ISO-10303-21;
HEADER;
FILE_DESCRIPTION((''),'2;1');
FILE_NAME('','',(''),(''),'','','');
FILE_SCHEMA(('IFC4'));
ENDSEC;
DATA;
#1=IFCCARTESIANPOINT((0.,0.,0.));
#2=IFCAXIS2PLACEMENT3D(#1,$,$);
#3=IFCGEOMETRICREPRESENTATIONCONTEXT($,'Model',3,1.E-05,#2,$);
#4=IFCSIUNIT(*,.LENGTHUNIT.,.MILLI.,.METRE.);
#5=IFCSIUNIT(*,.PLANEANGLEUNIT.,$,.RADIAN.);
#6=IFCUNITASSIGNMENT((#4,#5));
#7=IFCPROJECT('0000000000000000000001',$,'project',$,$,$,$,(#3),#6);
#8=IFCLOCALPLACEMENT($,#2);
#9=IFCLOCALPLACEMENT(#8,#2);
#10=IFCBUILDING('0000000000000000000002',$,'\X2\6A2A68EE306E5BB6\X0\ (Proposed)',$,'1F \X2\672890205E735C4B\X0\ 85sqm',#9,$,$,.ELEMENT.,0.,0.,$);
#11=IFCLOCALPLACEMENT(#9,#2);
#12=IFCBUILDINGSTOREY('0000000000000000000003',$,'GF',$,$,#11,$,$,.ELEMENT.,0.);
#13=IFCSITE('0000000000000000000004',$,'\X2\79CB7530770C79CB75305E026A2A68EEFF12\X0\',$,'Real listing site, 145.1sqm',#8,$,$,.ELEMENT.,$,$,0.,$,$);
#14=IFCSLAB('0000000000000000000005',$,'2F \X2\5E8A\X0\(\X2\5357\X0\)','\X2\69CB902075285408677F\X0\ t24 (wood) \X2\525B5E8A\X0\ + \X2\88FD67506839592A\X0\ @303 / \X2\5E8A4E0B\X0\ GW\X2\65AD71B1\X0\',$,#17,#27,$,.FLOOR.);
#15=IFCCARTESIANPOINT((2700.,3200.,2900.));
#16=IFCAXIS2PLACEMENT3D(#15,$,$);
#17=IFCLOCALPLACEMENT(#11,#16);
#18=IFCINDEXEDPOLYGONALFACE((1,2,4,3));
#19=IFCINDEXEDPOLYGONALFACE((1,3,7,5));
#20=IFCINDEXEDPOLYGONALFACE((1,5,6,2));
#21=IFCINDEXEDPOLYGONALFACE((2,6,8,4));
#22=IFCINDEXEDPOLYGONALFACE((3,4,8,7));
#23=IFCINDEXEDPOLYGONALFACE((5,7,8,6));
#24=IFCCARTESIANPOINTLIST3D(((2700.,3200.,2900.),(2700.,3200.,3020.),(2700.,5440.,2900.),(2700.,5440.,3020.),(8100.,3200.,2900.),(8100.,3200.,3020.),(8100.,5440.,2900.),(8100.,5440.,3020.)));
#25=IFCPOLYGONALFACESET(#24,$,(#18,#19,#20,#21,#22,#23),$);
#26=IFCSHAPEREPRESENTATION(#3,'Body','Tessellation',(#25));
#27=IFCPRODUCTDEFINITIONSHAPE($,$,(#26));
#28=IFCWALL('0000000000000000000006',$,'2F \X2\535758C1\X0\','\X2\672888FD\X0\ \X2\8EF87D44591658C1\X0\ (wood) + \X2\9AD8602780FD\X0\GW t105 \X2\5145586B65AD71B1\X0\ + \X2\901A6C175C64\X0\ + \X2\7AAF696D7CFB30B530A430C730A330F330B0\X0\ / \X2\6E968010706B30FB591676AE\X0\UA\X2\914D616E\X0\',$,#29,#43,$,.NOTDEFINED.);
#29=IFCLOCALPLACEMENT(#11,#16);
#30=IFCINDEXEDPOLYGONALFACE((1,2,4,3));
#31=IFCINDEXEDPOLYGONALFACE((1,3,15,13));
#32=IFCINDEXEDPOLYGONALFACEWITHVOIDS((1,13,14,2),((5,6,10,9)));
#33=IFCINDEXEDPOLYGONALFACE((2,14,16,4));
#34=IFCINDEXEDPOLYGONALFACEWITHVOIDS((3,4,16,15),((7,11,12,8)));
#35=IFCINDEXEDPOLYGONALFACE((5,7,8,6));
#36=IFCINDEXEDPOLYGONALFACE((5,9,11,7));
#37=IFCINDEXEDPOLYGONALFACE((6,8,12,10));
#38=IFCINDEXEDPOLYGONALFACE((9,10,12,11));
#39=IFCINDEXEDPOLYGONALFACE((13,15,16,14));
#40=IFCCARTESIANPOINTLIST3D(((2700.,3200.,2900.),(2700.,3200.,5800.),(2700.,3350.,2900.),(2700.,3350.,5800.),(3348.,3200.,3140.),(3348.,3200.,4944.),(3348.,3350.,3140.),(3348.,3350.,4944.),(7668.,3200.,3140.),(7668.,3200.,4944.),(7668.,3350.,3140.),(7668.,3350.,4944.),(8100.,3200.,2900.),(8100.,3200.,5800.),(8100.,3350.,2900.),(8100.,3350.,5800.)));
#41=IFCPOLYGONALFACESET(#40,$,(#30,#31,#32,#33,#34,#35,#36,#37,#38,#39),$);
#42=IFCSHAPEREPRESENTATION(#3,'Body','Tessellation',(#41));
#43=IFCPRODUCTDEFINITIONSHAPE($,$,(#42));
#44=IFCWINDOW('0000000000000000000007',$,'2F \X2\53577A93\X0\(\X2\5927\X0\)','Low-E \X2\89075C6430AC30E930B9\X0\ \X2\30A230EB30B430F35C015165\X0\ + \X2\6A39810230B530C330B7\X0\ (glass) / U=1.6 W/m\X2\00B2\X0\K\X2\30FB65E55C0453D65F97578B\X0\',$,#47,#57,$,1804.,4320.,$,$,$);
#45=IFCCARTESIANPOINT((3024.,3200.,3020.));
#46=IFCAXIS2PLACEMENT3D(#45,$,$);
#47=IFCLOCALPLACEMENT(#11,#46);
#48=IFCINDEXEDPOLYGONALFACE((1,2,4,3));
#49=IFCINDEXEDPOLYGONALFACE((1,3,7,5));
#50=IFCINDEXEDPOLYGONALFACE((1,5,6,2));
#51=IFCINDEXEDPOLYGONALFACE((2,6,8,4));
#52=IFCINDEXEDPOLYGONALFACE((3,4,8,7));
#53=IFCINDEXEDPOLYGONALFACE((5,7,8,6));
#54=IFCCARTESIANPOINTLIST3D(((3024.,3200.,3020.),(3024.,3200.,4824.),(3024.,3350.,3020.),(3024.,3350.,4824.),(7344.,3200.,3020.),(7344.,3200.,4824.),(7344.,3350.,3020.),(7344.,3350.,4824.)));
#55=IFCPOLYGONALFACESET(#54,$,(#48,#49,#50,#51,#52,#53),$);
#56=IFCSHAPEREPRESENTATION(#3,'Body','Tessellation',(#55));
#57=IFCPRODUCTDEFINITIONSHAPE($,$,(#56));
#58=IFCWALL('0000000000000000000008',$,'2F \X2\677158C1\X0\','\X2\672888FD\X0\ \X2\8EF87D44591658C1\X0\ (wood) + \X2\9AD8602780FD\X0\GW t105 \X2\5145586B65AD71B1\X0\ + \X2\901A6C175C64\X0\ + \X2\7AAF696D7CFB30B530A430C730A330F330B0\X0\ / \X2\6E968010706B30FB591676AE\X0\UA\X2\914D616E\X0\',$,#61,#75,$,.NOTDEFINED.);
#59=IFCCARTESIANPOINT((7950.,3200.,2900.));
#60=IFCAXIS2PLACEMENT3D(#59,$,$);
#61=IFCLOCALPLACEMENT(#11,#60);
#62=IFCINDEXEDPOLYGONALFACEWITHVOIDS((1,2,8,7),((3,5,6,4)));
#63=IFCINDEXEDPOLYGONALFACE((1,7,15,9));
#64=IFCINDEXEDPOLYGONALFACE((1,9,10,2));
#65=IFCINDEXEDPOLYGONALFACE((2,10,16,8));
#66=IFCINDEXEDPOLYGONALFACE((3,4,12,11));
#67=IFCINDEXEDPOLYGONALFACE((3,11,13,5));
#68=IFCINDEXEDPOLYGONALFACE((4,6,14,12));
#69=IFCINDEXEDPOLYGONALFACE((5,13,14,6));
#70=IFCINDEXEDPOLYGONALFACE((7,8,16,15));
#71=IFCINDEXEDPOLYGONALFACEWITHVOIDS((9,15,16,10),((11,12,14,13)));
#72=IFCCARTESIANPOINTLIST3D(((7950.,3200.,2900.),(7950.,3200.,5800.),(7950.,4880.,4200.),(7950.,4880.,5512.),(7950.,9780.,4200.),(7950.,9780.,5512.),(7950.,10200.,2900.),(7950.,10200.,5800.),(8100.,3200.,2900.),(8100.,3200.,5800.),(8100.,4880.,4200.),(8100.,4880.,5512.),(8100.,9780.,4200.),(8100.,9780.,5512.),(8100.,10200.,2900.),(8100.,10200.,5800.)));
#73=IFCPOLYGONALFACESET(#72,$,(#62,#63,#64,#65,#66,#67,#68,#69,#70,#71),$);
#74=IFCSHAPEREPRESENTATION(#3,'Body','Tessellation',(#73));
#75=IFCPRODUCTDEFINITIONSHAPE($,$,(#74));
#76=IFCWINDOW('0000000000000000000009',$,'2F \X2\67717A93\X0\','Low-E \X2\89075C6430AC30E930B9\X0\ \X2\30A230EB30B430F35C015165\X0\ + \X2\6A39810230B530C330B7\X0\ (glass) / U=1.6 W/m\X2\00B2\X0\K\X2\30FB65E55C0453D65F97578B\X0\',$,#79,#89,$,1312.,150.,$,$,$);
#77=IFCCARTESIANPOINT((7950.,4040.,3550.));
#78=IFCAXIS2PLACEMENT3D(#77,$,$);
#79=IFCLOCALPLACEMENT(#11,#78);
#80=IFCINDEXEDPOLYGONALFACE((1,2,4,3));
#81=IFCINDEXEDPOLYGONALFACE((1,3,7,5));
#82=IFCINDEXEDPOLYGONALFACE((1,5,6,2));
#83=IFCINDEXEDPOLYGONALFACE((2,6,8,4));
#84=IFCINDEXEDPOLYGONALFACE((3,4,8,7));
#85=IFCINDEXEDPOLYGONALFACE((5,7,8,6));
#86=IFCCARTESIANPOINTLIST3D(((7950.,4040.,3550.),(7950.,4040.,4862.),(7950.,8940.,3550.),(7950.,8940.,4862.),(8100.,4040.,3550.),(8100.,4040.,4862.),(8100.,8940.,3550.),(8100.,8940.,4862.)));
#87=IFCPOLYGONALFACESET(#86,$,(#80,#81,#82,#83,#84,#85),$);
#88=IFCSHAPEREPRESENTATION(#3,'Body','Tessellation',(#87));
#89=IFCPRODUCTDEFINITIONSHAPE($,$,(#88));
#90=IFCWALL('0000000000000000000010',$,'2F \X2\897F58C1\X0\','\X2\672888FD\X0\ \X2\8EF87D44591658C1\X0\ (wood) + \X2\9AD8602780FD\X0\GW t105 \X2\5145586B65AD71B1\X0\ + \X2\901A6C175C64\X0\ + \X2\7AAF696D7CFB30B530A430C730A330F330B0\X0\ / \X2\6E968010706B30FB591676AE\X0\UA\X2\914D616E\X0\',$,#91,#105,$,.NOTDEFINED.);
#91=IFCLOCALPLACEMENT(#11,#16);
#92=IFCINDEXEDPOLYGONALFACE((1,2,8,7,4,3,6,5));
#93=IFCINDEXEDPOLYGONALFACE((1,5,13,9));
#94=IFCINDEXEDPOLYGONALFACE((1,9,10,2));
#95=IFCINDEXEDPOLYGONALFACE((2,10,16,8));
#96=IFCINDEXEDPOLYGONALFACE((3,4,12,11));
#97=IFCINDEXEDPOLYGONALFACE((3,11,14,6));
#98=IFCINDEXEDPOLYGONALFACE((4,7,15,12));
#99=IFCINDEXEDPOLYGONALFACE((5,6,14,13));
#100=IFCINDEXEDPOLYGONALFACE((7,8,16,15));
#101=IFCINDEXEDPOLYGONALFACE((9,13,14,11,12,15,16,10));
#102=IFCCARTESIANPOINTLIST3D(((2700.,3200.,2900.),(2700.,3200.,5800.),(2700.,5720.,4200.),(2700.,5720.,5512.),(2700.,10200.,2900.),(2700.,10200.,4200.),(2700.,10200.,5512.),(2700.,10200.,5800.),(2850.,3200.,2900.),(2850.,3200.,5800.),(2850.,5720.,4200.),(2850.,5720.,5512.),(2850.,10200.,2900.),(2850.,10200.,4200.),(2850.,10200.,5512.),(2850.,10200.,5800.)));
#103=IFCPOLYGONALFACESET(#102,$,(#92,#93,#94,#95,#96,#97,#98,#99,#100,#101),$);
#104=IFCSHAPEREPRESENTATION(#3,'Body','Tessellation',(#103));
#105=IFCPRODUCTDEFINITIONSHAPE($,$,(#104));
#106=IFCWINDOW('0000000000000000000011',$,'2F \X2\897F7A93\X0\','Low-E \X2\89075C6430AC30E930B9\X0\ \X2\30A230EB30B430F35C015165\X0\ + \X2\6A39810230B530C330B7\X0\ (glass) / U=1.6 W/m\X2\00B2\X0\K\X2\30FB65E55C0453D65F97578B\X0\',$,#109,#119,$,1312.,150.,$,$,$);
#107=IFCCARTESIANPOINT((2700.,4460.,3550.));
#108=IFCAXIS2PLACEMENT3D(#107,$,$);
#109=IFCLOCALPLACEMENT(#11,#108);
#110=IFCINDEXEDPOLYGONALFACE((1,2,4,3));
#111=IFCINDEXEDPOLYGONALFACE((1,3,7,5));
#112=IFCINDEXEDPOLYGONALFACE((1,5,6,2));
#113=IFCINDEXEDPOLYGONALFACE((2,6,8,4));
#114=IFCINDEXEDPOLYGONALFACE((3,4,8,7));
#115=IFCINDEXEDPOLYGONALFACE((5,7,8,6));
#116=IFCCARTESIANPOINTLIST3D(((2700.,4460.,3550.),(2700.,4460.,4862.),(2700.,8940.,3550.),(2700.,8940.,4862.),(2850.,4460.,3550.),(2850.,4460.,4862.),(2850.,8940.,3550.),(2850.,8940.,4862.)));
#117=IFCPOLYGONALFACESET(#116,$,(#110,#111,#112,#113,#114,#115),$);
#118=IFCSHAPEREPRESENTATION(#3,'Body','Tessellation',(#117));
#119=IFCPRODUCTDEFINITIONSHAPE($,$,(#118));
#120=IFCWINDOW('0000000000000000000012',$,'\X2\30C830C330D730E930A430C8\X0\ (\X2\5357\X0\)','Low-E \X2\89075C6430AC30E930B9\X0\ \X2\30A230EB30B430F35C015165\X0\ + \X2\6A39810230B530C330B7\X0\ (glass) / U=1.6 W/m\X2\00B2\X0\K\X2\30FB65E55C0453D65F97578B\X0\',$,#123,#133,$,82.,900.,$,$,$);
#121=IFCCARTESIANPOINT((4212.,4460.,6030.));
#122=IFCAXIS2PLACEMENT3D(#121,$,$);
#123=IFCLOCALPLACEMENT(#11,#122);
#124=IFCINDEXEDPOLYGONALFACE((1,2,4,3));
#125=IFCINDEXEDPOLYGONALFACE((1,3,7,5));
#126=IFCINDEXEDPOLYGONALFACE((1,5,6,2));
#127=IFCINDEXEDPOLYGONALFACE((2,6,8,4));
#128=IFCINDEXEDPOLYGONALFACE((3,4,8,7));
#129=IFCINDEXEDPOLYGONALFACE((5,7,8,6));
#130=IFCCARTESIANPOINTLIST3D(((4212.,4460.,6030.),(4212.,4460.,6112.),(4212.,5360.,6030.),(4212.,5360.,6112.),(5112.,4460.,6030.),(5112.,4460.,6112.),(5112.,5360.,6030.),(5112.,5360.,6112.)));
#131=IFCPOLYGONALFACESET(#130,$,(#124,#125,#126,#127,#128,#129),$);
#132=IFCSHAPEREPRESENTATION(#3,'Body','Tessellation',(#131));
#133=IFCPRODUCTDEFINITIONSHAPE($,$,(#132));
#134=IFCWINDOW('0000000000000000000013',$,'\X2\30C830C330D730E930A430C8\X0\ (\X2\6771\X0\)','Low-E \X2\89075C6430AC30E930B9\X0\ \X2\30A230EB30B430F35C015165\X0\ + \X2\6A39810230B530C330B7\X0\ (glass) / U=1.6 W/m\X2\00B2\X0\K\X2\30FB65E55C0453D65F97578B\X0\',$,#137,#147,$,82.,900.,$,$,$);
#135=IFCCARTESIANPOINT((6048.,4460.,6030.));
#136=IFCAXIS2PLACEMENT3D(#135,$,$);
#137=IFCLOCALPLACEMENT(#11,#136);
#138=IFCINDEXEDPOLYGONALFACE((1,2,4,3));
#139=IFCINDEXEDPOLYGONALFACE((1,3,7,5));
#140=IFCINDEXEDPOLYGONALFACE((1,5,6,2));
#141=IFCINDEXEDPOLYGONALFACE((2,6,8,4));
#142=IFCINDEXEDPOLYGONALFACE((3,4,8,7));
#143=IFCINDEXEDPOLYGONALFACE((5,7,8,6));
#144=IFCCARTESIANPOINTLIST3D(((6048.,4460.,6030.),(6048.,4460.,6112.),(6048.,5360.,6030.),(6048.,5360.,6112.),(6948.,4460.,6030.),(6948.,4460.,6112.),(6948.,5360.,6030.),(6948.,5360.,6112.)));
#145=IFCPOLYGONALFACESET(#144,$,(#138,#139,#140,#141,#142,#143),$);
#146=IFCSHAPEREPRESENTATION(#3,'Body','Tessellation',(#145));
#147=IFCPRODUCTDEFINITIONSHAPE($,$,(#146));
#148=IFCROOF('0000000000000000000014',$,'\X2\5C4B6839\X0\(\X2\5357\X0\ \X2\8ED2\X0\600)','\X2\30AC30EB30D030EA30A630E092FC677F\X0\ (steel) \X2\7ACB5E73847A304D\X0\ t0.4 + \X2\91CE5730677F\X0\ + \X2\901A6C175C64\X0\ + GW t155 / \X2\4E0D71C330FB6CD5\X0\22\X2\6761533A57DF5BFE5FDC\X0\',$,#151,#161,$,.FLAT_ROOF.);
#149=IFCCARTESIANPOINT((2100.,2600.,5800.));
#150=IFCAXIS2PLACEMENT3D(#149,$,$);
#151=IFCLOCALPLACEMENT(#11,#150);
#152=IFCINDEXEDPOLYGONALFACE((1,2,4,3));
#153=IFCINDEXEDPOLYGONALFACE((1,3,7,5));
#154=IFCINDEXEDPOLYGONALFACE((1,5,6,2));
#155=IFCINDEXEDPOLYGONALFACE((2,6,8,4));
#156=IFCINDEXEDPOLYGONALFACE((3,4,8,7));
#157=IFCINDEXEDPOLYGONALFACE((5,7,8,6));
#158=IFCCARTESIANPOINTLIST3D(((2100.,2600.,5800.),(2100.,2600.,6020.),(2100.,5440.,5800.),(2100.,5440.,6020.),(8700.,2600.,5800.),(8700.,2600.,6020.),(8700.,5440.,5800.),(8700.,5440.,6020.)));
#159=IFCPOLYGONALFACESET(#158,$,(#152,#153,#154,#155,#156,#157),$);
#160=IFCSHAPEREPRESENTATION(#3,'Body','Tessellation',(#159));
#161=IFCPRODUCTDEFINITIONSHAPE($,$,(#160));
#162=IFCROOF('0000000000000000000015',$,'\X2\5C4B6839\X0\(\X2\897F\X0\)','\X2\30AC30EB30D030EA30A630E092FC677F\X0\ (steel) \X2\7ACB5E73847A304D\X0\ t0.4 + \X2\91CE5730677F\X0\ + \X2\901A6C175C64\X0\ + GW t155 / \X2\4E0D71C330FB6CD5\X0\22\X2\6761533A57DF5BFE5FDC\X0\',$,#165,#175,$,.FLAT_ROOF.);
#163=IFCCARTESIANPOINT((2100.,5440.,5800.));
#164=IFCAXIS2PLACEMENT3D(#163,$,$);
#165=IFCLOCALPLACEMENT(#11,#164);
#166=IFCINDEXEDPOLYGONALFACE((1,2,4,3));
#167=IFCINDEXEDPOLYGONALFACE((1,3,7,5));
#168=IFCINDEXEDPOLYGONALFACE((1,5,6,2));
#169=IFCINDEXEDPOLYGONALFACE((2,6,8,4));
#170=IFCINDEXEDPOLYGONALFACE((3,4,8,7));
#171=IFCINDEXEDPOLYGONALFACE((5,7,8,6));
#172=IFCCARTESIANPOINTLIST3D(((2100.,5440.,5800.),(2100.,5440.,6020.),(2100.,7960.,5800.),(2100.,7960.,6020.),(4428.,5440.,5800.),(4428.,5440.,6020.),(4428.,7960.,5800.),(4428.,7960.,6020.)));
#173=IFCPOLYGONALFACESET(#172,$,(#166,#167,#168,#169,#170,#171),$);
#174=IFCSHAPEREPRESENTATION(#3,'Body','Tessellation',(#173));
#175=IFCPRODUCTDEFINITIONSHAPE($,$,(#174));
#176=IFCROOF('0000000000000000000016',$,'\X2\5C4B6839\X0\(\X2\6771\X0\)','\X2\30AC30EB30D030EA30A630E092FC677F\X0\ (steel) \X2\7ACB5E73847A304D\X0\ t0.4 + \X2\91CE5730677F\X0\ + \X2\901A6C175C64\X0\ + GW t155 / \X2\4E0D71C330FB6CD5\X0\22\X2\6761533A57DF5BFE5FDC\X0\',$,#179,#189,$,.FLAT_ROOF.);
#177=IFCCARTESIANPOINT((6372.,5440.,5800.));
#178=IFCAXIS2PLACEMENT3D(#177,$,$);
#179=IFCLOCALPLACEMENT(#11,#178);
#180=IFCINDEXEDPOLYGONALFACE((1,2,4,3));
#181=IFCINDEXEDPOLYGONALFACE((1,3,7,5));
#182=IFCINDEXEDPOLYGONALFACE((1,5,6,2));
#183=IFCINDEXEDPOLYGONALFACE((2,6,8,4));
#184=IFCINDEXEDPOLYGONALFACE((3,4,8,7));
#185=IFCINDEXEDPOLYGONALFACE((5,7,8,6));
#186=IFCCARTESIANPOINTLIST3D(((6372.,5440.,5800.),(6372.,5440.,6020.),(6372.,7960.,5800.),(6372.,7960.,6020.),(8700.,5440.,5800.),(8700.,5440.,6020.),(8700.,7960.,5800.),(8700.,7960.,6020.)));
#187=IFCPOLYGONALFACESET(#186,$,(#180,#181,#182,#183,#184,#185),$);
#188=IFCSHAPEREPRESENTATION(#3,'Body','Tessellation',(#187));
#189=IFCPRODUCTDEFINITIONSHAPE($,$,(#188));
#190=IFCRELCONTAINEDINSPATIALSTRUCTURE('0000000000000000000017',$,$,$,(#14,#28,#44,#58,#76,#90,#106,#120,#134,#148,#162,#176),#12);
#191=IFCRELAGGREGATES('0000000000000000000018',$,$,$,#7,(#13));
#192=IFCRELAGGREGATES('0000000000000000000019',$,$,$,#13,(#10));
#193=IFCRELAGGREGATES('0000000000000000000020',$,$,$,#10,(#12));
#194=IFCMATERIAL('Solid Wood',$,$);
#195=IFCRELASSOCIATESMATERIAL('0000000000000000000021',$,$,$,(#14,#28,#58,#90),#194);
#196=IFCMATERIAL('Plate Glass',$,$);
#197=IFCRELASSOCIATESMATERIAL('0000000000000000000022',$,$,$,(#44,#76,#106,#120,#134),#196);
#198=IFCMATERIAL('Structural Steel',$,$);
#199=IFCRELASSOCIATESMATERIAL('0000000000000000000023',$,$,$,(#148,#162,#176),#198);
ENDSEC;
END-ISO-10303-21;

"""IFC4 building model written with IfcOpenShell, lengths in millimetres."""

from ifc_helpers import new_model, si_unit, frame, frame_2d, origin, place, context, project, spatial, rectangle, extrude, material, element, fill, save


model = new_model("IFC4")

# Units and contexts
model_context = context("Model", 3, precision=1e-05, world=origin())
ifc_project = project(units=[si_unit("LENGTHUNIT", "METRE", prefix="MILLI"), si_unit("PLANEANGLEUNIT", "RADIAN")], contexts=[model_context])

# Site, building, storey
site_placement = place(None, origin())
site = spatial("IfcSite", under=ifc_project, at=site_placement, Name="秋田県秋田市横森２", ObjectType="Real listing site, 145.1sqm", CompositionType="ELEMENT", RefElevation=0.0)
building_placement = place(site_placement, origin())
building = spatial("IfcBuilding", under=site, at=building_placement, Name="横森の家 (Proposed)", ObjectType="1F 木造平屋 85sqm", CompositionType="ELEMENT", ElevationOfRefHeight=0.0, ElevationOfTerrain=0.0)
storey_placement = place(building_placement, origin())
storey = spatial("IfcBuildingStorey", under=building, at=storey_placement, Name="GF", CompositionType="ELEMENT", Elevation=0.0)

# Slab
ifc_material_1 = material(Name="Solid Wood")
slab_placement = place(storey_placement, frame((2700.0, 3200.0, 2900.0)))
element("IfcSlab", 1, at=slab_placement, inside=storey, material=ifc_material_1, Name="2F 床(南)", Description="構造用合板 t24 (wood) 剛床 + 製材根太 @303 / 床下 GW断熱", PredefinedType="FLOOR", context=model_context, shape_type="SweptSolid", body=[
    extrude(rectangle(XDim=5400.0, YDim=2240.0, at=frame_2d((2700.0, 1120.0))), frame((2700.0, 3200.0, 2900.0)), (0.0, 0.0, 1.0), 120.0),
])

# Walls, openings, windows
wall_1_placement = place(storey_placement, frame((2700.0, 3200.0, 2900.0)))
wall_1 = element("IfcWall", 2, at=wall_1_placement, inside=storey, material=ifc_material_1, Name="2F 南壁", Description="木製 軸組外壁 (wood) + 高性能GW t105 充填断熱 + 通気層 + 窯業系サイディング / 準耐火・外皮UA配慮", PredefinedType="NOTDEFINED", context=model_context, shape_type="SweptSolid", body=[
    extrude(rectangle(XDim=5400.0, YDim=150.0, at=frame_2d((2700.0, 75.0))), frame((2700.0, 3200.0, 2900.0)), (0.0, 0.0, 1.0), 2900.0),
])
opening_1_placement = place(storey_placement, frame((3024.0, 3200.0, 3020.0)))
opening_1 = element("IfcOpeningElement", 3, at=opening_1_placement, cuts=wall_1, PredefinedType="NOTDEFINED", context=model_context, shape_type="SweptSolid", body=[
    extrude(rectangle(XDim=4320.0, YDim=150.0, at=frame_2d((2160.0, 75.0))), frame((3024.0, 3200.0, 3020.0)), (0.0, 0.0, 1.0), 1804.0),
])
ifc_material_2 = material(Name="Plate Glass")
window_1_placement = place(storey_placement, frame((3024.0, 3200.0, 3020.0)))
window_1 = element("IfcWindow", 4, at=window_1_placement, inside=storey, material=ifc_material_2, Name="2F 南窓(大)", Description="Low-E 複層ガラス アルゴン封入 + 樹脂サッシ (glass) / U=1.6 W/m²K・日射取得型", OverallHeight=1804.0, OverallWidth=4320.0, context=model_context, shape_type="SweptSolid", body=[
    extrude(rectangle(XDim=4320.0, YDim=150.0, at=frame_2d((2160.0, 75.0))), frame((3024.0, 3200.0, 3020.0)), (0.0, 0.0, 1.0), 1804.0),
])
fill(opening_1, window_1)
wall_2_placement = place(storey_placement, frame((7950.0, 3200.0, 2900.0)))
wall_2 = element("IfcWall", 5, at=wall_2_placement, inside=storey, material=ifc_material_1, Name="2F 東壁", Description="木製 軸組外壁 (wood) + 高性能GW t105 充填断熱 + 通気層 + 窯業系サイディング / 準耐火・外皮UA配慮", PredefinedType="NOTDEFINED", context=model_context, shape_type="SweptSolid", body=[
    extrude(rectangle(XDim=150.0, YDim=7000.0, at=frame_2d((75.0, 3500.0))), frame((7950.0, 3200.0, 2900.0)), (0.0, 0.0, 1.0), 2900.0),
])
opening_2_placement = place(storey_placement, frame((7950.0, 4040.0, 3550.0)))
opening_2 = element("IfcOpeningElement", 6, at=opening_2_placement, cuts=wall_2, PredefinedType="NOTDEFINED", context=model_context, shape_type="SweptSolid", body=[
    extrude(rectangle(XDim=150.0, YDim=4900.0, at=frame_2d((75.0, 2450.0))), frame((7950.0, 4040.0, 3550.0)), (0.0, 0.0, 1.0), 1312.0),
])
window_2_placement = place(storey_placement, frame((7950.0, 4040.0, 3550.0)))
window_2 = element("IfcWindow", 7, at=window_2_placement, inside=storey, material=ifc_material_2, Name="2F 東窓", Description="Low-E 複層ガラス アルゴン封入 + 樹脂サッシ (glass) / U=1.6 W/m²K・日射取得型", OverallHeight=1312.0, OverallWidth=150.0, context=model_context, shape_type="SweptSolid", body=[
    extrude(rectangle(XDim=150.0, YDim=4900.0, at=frame_2d((75.0, 2450.0))), frame((7950.0, 4040.0, 3550.0)), (0.0, 0.0, 1.0), 1312.0),
])
fill(opening_2, window_2)
wall_3_placement = place(storey_placement, frame((2700.0, 3200.0, 2900.0)))
wall_3 = element("IfcWall", 8, at=wall_3_placement, inside=storey, material=ifc_material_1, Name="2F 西壁", Description="木製 軸組外壁 (wood) + 高性能GW t105 充填断熱 + 通気層 + 窯業系サイディング / 準耐火・外皮UA配慮", PredefinedType="NOTDEFINED", context=model_context, shape_type="SweptSolid", body=[
    extrude(rectangle(XDim=150.0, YDim=7000.0, at=frame_2d((75.0, 3500.0))), frame((2700.0, 3200.0, 2900.0)), (0.0, 0.0, 1.0), 2900.0),
])
opening_3_placement = place(storey_placement, frame((2700.0, 4460.0, 3550.0)))
opening_3 = element("IfcOpeningElement", 9, at=opening_3_placement, cuts=wall_3, PredefinedType="NOTDEFINED", context=model_context, shape_type="SweptSolid", body=[
    extrude(rectangle(XDim=150.0, YDim=4480.0, at=frame_2d((75.0, 2240.0))), frame((2700.0, 4460.0, 3550.0)), (0.0, 0.0, 1.0), 1312.0),
])
window_3_placement = place(storey_placement, frame((2700.0, 4460.0, 3550.0)))
window_3 = element("IfcWindow", 10, at=window_3_placement, inside=storey, material=ifc_material_2, Name="2F 西窓", Description="Low-E 複層ガラス アルゴン封入 + 樹脂サッシ (glass) / U=1.6 W/m²K・日射取得型", OverallHeight=1312.0, OverallWidth=150.0, context=model_context, shape_type="SweptSolid", body=[
    extrude(rectangle(XDim=150.0, YDim=4480.0, at=frame_2d((75.0, 2240.0))), frame((2700.0, 4460.0, 3550.0)), (0.0, 0.0, 1.0), 1312.0),
])
fill(opening_3, window_3)

# Windows
window_4_placement = place(storey_placement, frame((4212.0, 4460.0, 6030.0)))
element("IfcWindow", 11, at=window_4_placement, inside=storey, material=ifc_material_2, Name="トップライト (南)", Description="Low-E 複層ガラス アルゴン封入 + 樹脂サッシ (glass) / U=1.6 W/m²K・日射取得型", OverallHeight=82.0, OverallWidth=900.0, context=model_context, shape_type="SweptSolid", body=[
    extrude(rectangle(XDim=900.0, YDim=900.0, at=frame_2d((450.0, 450.0))), frame((4212.0, 4460.0, 6030.0)), (0.0, 0.0, 1.0), 82.0),
])
window_5_placement = place(storey_placement, frame((6048.0, 4460.0, 6030.0)))
element("IfcWindow", 12, at=window_5_placement, inside=storey, material=ifc_material_2, Name="トップライト (東)", Description="Low-E 複層ガラス アルゴン封入 + 樹脂サッシ (glass) / U=1.6 W/m²K・日射取得型", OverallHeight=82.0, OverallWidth=900.0, context=model_context, shape_type="SweptSolid", body=[
    extrude(rectangle(XDim=900.0, YDim=900.0, at=frame_2d((450.0, 450.0))), frame((6048.0, 4460.0, 6030.0)), (0.0, 0.0, 1.0), 82.0),
])

# Roofs
ifc_material_3 = material(Name="Structural Steel")
roof_1_placement = place(storey_placement, frame((2100.0, 2600.0, 5800.0)))
element("IfcRoof", 13, at=roof_1_placement, inside=storey, material=ifc_material_3, Name="屋根(南 軒600)", Description="ガルバリウム鋼板 (steel) 立平葺き t0.4 + 野地板 + 通気層 + GW t155 / 不燃・法22条区域対応", PredefinedType="FLAT_ROOF", context=model_context, shape_type="SweptSolid", body=[
    extrude(rectangle(XDim=6600.0, YDim=2840.0, at=frame_2d((3300.0, 1420.0))), frame((2100.0, 2600.0, 5800.0)), (0.0, 0.0, 1.0), 220.0),
])
roof_2_placement = place(storey_placement, frame((2100.0, 5440.0, 5800.0)))
element("IfcRoof", 14, at=roof_2_placement, inside=storey, material=ifc_material_3, Name="屋根(西)", Description="ガルバリウム鋼板 (steel) 立平葺き t0.4 + 野地板 + 通気層 + GW t155 / 不燃・法22条区域対応", PredefinedType="FLAT_ROOF", context=model_context, shape_type="SweptSolid", body=[
    extrude(rectangle(XDim=2328.0, YDim=2520.0, at=frame_2d((1164.0, 1260.0))), frame((2100.0, 5440.0, 5800.0)), (0.0, 0.0, 1.0), 220.0),
])
roof_3_placement = place(storey_placement, frame((6372.0, 5440.0, 5800.0)))
element("IfcRoof", 15, at=roof_3_placement, inside=storey, material=ifc_material_3, Name="屋根(東)", Description="ガルバリウム鋼板 (steel) 立平葺き t0.4 + 野地板 + 通気層 + GW t155 / 不燃・法22条区域対応", PredefinedType="FLAT_ROOF", context=model_context, shape_type="SweptSolid", body=[
    extrude(rectangle(XDim=2328.0, YDim=2520.0, at=frame_2d((1164.0, 1260.0))), frame((6372.0, 5440.0, 5800.0)), (0.0, 0.0, 1.0), 220.0),
])

save(model, "model.ifc")
